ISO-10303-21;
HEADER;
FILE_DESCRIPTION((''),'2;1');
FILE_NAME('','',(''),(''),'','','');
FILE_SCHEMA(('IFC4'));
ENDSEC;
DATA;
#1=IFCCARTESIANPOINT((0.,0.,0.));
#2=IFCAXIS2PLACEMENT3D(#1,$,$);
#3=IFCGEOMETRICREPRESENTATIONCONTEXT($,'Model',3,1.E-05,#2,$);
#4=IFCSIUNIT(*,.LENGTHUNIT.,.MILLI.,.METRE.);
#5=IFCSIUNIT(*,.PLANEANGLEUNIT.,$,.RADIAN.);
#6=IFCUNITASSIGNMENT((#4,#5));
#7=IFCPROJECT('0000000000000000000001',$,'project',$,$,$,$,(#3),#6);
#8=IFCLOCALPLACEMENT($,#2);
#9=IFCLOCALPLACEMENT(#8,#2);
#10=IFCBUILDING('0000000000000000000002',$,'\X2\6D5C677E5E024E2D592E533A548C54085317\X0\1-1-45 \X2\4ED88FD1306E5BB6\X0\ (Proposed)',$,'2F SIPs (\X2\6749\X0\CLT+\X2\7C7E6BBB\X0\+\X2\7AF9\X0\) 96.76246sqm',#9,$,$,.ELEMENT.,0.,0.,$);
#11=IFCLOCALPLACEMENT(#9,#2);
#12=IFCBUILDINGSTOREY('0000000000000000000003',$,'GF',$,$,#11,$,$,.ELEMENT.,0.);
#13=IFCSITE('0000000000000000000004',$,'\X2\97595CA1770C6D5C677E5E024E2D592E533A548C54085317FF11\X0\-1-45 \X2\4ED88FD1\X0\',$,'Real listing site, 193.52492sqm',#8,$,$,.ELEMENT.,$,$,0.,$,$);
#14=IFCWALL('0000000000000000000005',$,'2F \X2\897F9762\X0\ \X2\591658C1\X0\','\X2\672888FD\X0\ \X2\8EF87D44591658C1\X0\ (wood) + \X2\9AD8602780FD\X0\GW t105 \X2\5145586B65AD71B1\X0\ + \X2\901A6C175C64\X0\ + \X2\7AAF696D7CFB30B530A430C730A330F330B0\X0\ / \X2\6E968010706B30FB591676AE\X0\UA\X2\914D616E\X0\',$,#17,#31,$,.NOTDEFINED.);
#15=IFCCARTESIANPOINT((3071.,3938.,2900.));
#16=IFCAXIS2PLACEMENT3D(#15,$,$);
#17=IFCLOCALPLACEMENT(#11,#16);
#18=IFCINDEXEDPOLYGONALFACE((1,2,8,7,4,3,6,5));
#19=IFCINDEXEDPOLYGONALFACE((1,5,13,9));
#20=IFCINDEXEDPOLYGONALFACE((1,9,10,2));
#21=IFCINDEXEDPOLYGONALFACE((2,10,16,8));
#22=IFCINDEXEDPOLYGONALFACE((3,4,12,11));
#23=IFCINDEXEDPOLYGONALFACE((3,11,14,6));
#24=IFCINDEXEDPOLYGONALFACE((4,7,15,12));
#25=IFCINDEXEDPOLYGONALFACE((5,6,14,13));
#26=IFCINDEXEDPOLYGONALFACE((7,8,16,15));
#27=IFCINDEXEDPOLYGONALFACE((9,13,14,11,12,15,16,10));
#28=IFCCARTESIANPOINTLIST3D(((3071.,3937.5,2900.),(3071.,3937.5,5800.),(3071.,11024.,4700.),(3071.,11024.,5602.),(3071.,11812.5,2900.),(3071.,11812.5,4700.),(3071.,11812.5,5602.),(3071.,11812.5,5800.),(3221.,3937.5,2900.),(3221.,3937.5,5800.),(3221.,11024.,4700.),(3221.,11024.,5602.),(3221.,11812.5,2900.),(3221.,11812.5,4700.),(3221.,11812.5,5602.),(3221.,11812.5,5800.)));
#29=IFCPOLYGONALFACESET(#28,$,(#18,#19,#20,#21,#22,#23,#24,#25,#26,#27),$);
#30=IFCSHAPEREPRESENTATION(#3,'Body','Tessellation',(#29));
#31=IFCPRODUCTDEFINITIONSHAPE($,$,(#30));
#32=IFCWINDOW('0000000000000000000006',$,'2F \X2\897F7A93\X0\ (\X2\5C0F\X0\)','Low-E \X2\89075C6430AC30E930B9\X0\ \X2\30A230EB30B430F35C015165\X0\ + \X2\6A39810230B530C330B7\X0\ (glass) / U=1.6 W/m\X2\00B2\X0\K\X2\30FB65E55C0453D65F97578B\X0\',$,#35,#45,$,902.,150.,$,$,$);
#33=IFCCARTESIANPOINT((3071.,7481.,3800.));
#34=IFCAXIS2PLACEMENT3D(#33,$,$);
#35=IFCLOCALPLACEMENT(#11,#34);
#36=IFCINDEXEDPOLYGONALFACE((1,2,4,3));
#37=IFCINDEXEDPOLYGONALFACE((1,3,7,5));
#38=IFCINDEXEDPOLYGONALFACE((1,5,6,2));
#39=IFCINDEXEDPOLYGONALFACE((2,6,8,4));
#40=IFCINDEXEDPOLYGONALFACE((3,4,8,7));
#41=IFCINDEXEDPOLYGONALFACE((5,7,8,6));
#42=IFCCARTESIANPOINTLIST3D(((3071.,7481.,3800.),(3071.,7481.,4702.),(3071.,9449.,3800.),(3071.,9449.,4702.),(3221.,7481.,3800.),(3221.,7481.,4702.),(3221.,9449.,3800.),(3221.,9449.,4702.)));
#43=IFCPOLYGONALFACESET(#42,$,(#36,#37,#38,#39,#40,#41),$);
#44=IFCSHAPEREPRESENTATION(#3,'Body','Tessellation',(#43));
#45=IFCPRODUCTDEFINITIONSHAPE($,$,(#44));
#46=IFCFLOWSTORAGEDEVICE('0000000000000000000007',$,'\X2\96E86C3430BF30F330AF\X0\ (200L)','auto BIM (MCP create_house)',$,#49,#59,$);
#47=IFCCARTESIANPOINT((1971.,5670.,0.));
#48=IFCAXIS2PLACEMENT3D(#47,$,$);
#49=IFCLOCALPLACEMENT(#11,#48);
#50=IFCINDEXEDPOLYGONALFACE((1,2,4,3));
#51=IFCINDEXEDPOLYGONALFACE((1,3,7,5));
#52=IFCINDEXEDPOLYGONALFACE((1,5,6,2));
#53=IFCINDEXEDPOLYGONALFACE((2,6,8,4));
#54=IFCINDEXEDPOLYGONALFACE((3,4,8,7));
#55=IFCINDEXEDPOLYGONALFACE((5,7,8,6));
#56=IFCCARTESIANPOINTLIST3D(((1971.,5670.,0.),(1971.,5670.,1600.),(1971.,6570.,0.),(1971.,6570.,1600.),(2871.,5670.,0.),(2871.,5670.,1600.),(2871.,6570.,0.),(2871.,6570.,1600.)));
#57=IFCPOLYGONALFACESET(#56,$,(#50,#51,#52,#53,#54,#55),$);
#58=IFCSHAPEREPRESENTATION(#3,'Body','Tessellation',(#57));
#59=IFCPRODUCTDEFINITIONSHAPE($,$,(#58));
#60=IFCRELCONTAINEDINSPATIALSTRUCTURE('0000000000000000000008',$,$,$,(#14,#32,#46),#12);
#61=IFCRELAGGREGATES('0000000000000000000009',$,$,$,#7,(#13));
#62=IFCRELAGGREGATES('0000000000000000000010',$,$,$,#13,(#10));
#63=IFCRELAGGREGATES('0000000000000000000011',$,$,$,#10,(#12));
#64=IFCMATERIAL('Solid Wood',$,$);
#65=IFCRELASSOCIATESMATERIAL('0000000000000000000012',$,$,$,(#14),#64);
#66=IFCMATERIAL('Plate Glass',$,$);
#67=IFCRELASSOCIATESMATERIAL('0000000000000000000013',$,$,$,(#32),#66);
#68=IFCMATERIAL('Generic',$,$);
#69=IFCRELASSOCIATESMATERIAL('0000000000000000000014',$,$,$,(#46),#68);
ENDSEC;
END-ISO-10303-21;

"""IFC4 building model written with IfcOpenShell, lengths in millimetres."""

from ifc_helpers import new_model, si_unit, frame, frame_2d, origin, place, context, project, spatial, rectangle, extrude, material, element, fill, save


model = new_model("IFC4")

# Units and contexts
model_context = context("Model", 3, precision=1e-05, world=origin())
ifc_project = project(units=[si_unit("LENGTHUNIT", "METRE", prefix="MILLI"), si_unit("PLANEANGLEUNIT", "RADIAN")], contexts=[model_context])

# Site, building, storey
site_placement = place(None, origin())
site = spatial("IfcSite", under=ifc_project, at=site_placement, Name="静岡県浜松市中央区和合北１-1-45 付近", ObjectType="Real listing site, 193.52492sqm", CompositionType="ELEMENT", RefElevation=0.0)
building_placement = place(site_placement, origin())
building = spatial("IfcBuilding", under=site, at=building_placement, Name="浜松市中央区和合北1-1-45 付近の家 (Proposed)", ObjectType="2F SIPs (杉CLT+籾殻+竹) 96.76246sqm", CompositionType="ELEMENT", ElevationOfRefHeight=0.0, ElevationOfTerrain=0.0)
storey_placement = place(building_placement, origin())
storey = spatial("IfcBuildingStorey", under=building, at=storey_placement, Name="GF", CompositionType="ELEMENT", Elevation=0.0)

# Shared definitions
ifc_material_1 = material(Name="Solid Wood")

# Shared definitions
ifc_material_2 = material(Name="Plate Glass")

# Wall, opening, window
wall_1_placement = place(storey_placement, frame((3071.0, 3938.0, 2900.0)))
wall_1 = element("IfcWall", 1, at=wall_1_placement, inside=storey, material=ifc_material_1, Name="2F 西面 外壁", Description="木製 軸組外壁 (wood) + 高性能GW t105 充填断熱 + 通気層 + 窯業系サイディング / 準耐火・外皮UA配慮", PredefinedType="NOTDEFINED", context=model_context, shape_type="SweptSolid", body=[
    extrude(rectangle(XDim=150.0, YDim=7875.0, at=frame_2d((75.0, 3937.0))), frame((3071.0, 3938.0, 2900.0)), (0.0, 0.0, 1.0), 2900.0),
])
opening_1_placement = place(storey_placement, frame((3071.0, 7481.0, 3800.0)))
opening_1 = element("IfcOpeningElement", 2, at=opening_1_placement, cuts=wall_1, PredefinedType="NOTDEFINED", context=model_context, shape_type="SweptSolid", body=[
    extrude(rectangle(XDim=150.0, YDim=1968.0, at=frame_2d((75.0, 984.0))), frame((3071.0, 7481.0, 3800.0)), (0.0, 0.0, 1.0), 902.0),
])
window_1_placement = place(storey_placement, frame((3071.0, 7481.0, 3800.0)))
window_1 = element("IfcWindow", 3, at=window_1_placement, inside=storey, material=ifc_material_2, Name="2F 西窓 (小)", Description="Low-E 複層ガラス アルゴン封入 + 樹脂サッシ (glass) / U=1.6 W/m²K・日射取得型", OverallHeight=902.0, OverallWidth=150.0, context=model_context, shape_type="SweptSolid", body=[
    extrude(rectangle(XDim=150.0, YDim=1968.0, at=frame_2d((75.0, 984.0))), frame((3071.0, 7481.0, 3800.0)), (0.0, 0.0, 1.0), 902.0),
])
fill(opening_1, window_1)

# Shared definitions
ifc_material_3 = material(Name="Generic")

# Flow storage device
flow_storage_device_placement = place(storey_placement, frame((1971.0, 5670.0, 0.0)))
element("IfcFlowStorageDevice", 4, at=flow_storage_device_placement, inside=storey, material=ifc_material_3, Name="雨水タンク (200L)", Description="auto BIM (MCP create_house)", context=model_context, shape_type="SweptSolid", body=[
    extrude(rectangle(XDim=900.0, YDim=900.0, at=frame_2d((450.0, 450.0))), frame((1971.0, 5670.0, 0.0)), (0.0, 0.0, 1.0), 1600.0),
])

save(model, "model.ifc")
